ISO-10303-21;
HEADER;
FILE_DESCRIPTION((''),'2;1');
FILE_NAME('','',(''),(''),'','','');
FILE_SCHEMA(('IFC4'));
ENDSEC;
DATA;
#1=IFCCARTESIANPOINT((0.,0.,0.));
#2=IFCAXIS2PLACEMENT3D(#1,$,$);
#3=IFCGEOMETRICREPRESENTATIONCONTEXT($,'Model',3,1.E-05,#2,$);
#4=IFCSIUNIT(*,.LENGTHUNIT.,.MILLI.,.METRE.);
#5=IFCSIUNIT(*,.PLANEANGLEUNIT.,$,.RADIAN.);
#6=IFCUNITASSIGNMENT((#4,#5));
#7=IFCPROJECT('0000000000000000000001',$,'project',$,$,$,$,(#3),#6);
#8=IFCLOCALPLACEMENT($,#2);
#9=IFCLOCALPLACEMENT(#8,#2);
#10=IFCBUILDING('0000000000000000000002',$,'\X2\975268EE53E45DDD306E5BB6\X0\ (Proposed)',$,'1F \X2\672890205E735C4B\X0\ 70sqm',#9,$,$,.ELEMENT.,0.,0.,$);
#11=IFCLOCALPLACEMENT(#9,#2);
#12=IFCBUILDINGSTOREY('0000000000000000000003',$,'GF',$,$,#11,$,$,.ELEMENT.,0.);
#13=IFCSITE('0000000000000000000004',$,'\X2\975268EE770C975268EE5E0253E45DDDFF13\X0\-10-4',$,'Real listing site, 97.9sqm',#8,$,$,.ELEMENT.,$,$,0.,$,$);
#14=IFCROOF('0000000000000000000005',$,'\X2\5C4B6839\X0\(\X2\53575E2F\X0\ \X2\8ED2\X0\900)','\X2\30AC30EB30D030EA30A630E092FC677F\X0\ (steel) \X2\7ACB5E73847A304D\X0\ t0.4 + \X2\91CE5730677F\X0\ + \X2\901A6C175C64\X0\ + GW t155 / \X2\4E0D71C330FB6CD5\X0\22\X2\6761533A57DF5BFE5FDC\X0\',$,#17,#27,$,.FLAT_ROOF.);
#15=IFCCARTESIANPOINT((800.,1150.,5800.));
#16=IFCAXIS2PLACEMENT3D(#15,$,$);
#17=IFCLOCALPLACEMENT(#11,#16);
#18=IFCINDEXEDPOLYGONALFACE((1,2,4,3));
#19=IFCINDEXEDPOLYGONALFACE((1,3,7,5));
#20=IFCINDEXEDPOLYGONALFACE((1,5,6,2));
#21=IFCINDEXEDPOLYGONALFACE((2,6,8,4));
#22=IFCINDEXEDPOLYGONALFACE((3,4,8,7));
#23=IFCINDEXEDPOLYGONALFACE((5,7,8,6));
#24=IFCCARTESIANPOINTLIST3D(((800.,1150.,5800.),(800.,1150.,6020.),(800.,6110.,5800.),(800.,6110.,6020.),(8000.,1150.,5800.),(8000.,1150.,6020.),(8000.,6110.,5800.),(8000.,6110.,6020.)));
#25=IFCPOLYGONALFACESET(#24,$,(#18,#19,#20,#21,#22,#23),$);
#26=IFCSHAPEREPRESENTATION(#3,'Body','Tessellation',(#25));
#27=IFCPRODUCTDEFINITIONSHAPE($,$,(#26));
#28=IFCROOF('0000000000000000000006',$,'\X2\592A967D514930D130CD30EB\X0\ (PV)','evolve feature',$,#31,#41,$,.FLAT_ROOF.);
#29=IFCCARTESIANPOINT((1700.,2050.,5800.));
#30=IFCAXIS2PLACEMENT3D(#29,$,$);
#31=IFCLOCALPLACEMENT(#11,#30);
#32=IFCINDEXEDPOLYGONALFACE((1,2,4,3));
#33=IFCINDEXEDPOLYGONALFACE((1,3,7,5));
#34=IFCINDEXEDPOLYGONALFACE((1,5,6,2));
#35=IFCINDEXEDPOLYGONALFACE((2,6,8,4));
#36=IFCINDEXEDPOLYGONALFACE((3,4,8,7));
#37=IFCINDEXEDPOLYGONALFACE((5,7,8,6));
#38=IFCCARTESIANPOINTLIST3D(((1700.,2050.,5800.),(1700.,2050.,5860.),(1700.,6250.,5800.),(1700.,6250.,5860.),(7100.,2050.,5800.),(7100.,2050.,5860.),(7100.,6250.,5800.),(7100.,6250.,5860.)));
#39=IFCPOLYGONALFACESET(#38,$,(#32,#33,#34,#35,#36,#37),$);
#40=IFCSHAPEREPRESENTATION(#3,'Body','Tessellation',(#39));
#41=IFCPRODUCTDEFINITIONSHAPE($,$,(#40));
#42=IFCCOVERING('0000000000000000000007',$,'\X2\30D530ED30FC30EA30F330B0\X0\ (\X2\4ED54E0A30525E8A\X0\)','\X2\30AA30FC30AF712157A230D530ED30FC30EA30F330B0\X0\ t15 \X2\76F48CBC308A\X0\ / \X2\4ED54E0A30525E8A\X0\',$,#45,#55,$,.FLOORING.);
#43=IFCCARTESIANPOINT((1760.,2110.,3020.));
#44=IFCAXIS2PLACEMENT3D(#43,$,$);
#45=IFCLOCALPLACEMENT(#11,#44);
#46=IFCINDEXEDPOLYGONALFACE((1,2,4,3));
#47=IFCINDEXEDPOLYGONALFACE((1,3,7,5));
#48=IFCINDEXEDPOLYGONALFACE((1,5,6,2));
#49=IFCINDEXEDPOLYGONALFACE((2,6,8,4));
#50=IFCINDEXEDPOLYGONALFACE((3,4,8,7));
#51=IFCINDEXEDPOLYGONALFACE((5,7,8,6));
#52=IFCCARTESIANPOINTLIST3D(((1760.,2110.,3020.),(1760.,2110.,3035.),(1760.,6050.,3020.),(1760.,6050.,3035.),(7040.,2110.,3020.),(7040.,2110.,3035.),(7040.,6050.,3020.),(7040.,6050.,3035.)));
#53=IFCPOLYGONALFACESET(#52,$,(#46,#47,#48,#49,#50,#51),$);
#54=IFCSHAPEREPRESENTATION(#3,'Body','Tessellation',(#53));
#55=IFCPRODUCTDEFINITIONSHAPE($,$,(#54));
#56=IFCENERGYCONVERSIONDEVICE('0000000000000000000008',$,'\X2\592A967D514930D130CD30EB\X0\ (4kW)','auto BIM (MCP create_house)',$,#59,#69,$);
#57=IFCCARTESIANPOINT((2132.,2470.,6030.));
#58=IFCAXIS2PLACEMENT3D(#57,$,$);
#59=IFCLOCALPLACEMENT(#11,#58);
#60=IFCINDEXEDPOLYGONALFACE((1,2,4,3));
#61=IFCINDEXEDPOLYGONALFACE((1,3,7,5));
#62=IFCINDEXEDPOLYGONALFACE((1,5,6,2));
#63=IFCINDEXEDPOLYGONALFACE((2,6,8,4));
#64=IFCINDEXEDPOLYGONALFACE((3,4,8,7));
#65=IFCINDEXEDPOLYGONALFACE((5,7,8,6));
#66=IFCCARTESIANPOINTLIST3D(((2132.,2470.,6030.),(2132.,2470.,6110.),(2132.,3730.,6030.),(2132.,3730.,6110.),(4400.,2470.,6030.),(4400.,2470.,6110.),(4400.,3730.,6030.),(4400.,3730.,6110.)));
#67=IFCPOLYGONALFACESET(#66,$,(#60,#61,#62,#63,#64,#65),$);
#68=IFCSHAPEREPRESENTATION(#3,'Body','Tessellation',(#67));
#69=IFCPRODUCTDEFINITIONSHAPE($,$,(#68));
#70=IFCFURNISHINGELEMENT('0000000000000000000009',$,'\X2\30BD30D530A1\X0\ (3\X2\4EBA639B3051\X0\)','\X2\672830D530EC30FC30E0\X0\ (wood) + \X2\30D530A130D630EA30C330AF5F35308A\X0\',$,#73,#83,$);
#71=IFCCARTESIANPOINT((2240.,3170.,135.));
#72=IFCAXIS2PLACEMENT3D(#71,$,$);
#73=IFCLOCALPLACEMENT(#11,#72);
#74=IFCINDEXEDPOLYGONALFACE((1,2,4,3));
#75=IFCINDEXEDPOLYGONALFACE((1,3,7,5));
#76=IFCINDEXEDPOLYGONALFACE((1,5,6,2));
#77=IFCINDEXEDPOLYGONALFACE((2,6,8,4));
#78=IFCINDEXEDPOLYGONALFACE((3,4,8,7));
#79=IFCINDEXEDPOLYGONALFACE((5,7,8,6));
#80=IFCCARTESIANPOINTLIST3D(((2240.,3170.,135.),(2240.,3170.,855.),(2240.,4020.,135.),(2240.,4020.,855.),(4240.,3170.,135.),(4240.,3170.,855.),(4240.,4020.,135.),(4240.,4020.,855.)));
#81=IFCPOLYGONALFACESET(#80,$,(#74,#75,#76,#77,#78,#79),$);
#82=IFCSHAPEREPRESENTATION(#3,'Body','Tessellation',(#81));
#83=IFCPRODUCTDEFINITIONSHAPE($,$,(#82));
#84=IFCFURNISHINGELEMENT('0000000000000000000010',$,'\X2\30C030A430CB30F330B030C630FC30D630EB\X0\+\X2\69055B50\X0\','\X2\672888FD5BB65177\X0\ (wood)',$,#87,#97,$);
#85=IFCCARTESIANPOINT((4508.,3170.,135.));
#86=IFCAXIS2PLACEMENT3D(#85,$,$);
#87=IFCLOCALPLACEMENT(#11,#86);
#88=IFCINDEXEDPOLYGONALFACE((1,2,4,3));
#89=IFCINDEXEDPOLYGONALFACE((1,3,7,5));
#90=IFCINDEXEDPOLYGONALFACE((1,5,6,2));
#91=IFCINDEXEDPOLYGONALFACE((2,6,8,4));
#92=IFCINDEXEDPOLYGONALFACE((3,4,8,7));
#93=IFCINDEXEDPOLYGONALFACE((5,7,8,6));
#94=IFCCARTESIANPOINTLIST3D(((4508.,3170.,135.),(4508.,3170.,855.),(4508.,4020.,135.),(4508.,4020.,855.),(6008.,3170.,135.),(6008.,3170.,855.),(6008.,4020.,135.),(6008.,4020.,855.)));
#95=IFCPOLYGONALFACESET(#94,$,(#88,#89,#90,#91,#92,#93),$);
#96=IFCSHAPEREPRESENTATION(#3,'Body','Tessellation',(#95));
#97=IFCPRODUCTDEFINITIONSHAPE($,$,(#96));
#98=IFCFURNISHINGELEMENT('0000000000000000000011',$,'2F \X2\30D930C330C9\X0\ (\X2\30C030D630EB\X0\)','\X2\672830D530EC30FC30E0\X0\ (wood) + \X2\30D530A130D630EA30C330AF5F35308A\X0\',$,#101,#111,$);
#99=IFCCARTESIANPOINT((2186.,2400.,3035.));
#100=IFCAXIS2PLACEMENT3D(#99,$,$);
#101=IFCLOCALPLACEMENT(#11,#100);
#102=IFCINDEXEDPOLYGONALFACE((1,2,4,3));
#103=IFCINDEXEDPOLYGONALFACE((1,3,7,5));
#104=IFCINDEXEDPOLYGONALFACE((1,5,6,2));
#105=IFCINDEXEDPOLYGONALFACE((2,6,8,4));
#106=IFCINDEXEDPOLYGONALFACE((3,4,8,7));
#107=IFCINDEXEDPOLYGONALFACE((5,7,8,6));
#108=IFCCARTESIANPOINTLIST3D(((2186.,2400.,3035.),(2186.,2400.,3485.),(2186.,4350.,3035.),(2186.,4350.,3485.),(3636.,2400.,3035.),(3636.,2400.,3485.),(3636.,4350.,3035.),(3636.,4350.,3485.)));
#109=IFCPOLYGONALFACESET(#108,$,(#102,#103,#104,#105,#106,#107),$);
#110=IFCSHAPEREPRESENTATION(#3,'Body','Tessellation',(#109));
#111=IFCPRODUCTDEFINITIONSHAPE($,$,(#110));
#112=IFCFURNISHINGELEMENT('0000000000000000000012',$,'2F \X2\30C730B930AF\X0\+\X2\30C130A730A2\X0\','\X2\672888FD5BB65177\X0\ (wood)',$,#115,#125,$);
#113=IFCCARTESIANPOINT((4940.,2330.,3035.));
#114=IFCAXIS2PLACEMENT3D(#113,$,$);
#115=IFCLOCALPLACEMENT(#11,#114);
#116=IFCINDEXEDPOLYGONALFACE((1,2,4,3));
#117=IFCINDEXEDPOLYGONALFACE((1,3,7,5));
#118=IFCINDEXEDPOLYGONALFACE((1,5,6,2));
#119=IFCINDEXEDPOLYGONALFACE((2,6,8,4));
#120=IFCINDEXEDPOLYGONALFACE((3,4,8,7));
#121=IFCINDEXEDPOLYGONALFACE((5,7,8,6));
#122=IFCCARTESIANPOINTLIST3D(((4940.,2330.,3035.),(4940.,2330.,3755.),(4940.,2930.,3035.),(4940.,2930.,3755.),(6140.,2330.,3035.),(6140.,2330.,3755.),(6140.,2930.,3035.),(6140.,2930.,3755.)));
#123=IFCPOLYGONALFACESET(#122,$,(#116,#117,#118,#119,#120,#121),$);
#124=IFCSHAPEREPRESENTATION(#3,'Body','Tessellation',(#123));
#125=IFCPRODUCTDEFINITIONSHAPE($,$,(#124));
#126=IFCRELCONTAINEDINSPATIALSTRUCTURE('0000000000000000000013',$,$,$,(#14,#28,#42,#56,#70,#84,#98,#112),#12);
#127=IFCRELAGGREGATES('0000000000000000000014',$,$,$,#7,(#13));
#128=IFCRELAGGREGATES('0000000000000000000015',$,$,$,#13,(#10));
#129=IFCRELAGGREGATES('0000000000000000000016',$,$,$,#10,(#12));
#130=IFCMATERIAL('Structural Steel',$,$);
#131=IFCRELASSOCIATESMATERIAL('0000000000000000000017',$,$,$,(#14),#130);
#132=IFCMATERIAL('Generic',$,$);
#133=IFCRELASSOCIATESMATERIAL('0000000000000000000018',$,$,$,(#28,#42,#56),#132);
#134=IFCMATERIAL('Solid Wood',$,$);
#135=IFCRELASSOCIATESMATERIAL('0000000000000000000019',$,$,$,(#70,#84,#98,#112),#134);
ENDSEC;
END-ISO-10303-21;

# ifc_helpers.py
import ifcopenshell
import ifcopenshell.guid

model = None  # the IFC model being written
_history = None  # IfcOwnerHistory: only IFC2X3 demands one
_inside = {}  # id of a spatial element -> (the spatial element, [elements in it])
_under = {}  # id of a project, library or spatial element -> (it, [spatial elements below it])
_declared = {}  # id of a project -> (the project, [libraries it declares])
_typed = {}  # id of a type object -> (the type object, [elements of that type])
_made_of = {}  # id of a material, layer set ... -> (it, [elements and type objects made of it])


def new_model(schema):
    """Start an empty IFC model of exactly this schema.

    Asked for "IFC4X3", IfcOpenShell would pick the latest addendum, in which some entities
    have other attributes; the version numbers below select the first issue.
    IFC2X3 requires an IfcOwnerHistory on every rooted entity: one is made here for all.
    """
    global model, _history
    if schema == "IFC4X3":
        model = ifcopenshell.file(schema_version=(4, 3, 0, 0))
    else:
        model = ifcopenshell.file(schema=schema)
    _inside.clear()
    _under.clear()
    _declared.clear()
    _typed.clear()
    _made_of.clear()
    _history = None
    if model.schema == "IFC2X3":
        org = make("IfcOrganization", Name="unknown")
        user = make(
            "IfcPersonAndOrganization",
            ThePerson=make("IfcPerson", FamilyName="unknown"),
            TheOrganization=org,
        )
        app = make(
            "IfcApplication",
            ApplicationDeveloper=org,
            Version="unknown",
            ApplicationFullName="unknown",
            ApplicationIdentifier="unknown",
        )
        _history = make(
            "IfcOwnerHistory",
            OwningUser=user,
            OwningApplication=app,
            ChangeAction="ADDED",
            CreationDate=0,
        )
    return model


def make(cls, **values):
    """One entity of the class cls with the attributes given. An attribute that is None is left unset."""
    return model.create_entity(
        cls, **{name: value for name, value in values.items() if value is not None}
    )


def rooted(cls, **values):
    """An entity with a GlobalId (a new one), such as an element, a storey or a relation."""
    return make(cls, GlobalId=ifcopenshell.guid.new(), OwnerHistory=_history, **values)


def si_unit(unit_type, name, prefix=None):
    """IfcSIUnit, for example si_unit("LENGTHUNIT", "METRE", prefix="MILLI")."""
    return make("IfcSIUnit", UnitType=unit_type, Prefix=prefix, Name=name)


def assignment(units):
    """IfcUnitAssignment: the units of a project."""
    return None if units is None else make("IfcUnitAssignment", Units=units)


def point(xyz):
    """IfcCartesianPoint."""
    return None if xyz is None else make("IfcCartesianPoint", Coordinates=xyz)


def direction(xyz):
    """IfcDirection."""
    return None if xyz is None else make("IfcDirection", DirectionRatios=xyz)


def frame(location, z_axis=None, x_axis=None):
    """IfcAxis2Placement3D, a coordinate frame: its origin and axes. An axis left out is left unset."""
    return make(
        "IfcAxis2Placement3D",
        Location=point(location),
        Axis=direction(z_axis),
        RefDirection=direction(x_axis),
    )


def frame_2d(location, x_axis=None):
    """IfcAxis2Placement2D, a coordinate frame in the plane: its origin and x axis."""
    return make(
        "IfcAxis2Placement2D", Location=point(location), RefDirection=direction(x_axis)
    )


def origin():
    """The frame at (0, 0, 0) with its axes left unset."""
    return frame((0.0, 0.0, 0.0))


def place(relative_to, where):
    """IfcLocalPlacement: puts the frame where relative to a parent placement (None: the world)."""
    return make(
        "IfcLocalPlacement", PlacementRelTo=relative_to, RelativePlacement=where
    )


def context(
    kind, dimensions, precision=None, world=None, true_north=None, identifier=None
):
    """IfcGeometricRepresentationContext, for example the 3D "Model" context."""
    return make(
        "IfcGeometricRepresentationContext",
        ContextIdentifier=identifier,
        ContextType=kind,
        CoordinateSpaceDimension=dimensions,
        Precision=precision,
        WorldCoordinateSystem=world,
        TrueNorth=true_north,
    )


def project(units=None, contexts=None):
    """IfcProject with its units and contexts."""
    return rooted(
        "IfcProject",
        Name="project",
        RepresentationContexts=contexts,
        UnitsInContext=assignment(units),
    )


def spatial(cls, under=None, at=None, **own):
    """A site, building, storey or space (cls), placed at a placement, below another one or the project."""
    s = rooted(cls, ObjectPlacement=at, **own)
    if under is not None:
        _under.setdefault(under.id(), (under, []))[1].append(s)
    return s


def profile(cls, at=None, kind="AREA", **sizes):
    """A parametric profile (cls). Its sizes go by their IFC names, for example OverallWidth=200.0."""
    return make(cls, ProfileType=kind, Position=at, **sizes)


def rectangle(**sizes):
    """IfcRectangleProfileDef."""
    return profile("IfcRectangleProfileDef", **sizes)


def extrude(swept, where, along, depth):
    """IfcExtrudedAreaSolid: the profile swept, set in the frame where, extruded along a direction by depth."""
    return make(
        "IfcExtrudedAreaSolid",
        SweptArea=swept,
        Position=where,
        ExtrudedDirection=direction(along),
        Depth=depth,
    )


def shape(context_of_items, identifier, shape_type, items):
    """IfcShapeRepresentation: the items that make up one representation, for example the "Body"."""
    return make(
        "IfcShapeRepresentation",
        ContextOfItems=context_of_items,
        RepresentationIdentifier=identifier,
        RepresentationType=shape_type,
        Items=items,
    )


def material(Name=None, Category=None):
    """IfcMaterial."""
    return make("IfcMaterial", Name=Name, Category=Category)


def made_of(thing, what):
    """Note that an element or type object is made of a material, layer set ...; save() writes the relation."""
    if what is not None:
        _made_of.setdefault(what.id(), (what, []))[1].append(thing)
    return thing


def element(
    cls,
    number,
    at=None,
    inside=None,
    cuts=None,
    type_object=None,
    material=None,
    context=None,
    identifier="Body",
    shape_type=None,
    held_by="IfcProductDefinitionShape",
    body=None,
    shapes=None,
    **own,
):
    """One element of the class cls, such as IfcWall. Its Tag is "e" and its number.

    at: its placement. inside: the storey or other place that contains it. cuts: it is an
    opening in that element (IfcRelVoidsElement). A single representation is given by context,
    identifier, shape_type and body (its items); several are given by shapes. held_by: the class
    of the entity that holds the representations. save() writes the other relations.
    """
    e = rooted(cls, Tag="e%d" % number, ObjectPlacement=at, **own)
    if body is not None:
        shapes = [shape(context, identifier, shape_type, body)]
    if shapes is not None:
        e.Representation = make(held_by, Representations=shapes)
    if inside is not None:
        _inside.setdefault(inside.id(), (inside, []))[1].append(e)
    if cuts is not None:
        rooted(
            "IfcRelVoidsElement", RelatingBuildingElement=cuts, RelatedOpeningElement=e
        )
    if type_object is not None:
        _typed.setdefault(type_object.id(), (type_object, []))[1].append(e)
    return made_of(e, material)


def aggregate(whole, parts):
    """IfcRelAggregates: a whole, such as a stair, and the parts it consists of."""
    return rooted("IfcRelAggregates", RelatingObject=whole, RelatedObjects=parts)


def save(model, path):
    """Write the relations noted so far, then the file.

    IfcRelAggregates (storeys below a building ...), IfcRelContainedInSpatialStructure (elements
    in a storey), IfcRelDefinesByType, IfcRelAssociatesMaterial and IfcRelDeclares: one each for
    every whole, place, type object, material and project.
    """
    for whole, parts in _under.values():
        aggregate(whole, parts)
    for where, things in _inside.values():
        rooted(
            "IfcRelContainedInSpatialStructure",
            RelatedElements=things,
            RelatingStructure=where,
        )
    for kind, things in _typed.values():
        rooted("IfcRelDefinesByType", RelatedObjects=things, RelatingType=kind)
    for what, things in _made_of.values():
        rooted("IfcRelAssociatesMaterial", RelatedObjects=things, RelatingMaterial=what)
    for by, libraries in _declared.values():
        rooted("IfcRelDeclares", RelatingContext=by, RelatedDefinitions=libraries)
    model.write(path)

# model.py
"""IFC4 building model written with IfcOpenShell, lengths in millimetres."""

from ifc_helpers import new_model, si_unit, frame, frame_2d, origin, place, context, project, spatial, rectangle, extrude, material, element, save


model = new_model("IFC4")

# Units and contexts
model_context = context("Model", 3, precision=1e-05, world=origin())
ifc_project = project(units=[si_unit("LENGTHUNIT", "METRE", prefix="MILLI"), si_unit("PLANEANGLEUNIT", "RADIAN")], contexts=[model_context])

# Site, building, storey
site_placement = place(None, origin())
site = spatial("IfcSite", under=ifc_project, at=site_placement, Name="青森県青森市古川３-10-4", ObjectType="Real listing site, 97.9sqm", CompositionType="ELEMENT", RefElevation=0.0)
building_placement = place(site_placement, origin())
building = spatial("IfcBuilding", under=site, at=building_placement, Name="青森古川の家 (Proposed)", ObjectType="1F 木造平屋 70sqm", CompositionType="ELEMENT", ElevationOfRefHeight=0.0, ElevationOfTerrain=0.0)
storey_placement = place(building_placement, origin())
storey = spatial("IfcBuildingStorey", under=building, at=storey_placement, Name="GF", CompositionType="ELEMENT", Elevation=0.0)

# Shared definitions
ifc_material_1 = material(Name="Solid Wood")

# Shared definitions
ifc_material_2 = material(Name="Generic")

# Roofs
ifc_material_3 = material(Name="Structural Steel")
for number, where, name in (
    (1, (800.0, 1150.0, 5800.0), "屋根(南帯 軒900)"),
):
    element("IfcRoof", number, at=place(storey_placement, frame(where)), inside=storey, material=ifc_material_3, Name=name, Description="ガルバリウム鋼板 (steel) 立平葺き t0.4 + 野地板 + 通気層 + GW t155 / 不燃・法22条区域対応", PredefinedType="FLAT_ROOF", context=model_context, shape_type="SweptSolid", body=[
        extrude(rectangle(XDim=7200.0, YDim=4960.0, at=frame_2d((3600.0, 2480.0))), frame((800.0, 1150.0, 5800.0)), (0.0, 0.0, 1.0), 220.0),
    ])
roof_placement = place(storey_placement, frame((1700.0, 2050.0, 5800.0)))
element("IfcRoof", 2, at=roof_placement, inside=storey, material=ifc_material_2, Name="太陽光パネル (PV)", Description="evolve feature", PredefinedType="FLAT_ROOF", context=model_context, shape_type="SweptSolid", body=[
    extrude(rectangle(XDim=5400.0, YDim=4200.0, at=frame_2d((2700.0, 2100.0))), frame((1700.0, 2050.0, 5800.0)), (0.0, 0.0, 1.0), 60.0),
])

# Covering
covering_placement = place(storey_placement, frame((1760.0, 2110.0, 3020.0)))
element("IfcCovering", 3, at=covering_placement, inside=storey, material=ifc_material_2, Name="フローリング (仕上げ床)", Description="オーク無垢フローリング t15 直貼り / 仕上げ床", PredefinedType="FLOORING", context=model_context, shape_type="SweptSolid", body=[
    extrude(rectangle(XDim=5280.0, YDim=3940.0, at=frame_2d((2640.0, 1970.0))), frame((1760.0, 2110.0, 3020.0)), (0.0, 0.0, 1.0), 15.0),
])

# Energy conversion device
energy_conversion_device_placement = place(storey_placement, frame((2132.0, 2470.0, 6030.0)))
element("IfcEnergyConversionDevice", 4, at=energy_conversion_device_placement, inside=storey, material=ifc_material_2, Name="太陽光パネル (4kW)", Description="auto BIM (MCP create_house)", context=model_context, shape_type="SweptSolid", body=[
    extrude(rectangle(XDim=2268.0, YDim=1260.0, at=frame_2d((1134.0, 630.0))), frame((2132.0, 2470.0, 6030.0)), (0.0, 0.0, 1.0), 80.0),
])

# Furnishing elements
furnishing_1_placement = place(storey_placement, frame((2240.0, 3170.0, 135.0)))
element("IfcFurnishingElement", 5, at=furnishing_1_placement, inside=storey, material=ifc_material_1, Name="ソファ (3人掛け)", Description="木フレーム (wood) + ファブリック張り", context=model_context, shape_type="SweptSolid", body=[
    extrude(rectangle(XDim=2000.0, YDim=850.0, at=frame_2d((1000.0, 425.0))), frame((2240.0, 3170.0, 135.0)), (0.0, 0.0, 1.0), 720.0),
])
furnishing_2_placement = place(storey_placement, frame((4508.0, 3170.0, 135.0)))
element("IfcFurnishingElement", 6, at=furnishing_2_placement, inside=storey, material=ifc_material_1, Name="ダイニングテーブル+椅子", Description="木製家具 (wood)", context=model_context, shape_type="SweptSolid", body=[
    extrude(rectangle(XDim=1500.0, YDim=850.0, at=frame_2d((750.0, 425.0))), frame((4508.0, 3170.0, 135.0)), (0.0, 0.0, 1.0), 720.0),
])
furnishing_3_placement = place(storey_placement, frame((2186.0, 2400.0, 3035.0)))
element("IfcFurnishingElement", 7, at=furnishing_3_placement, inside=storey, material=ifc_material_1, Name="2F ベッド (ダブル)", Description="木フレーム (wood) + ファブリック張り", context=model_context, shape_type="SweptSolid", body=[
    extrude(rectangle(XDim=1450.0, YDim=1950.0, at=frame_2d((725.0, 975.0))), frame((2186.0, 2400.0, 3035.0)), (0.0, 0.0, 1.0), 450.0),
])
furnishing_4_placement = place(storey_placement, frame((4940.0, 2330.0, 3035.0)))
element("IfcFurnishingElement", 8, at=furnishing_4_placement, inside=storey, material=ifc_material_1, Name="2F デスク+チェア", Description="木製家具 (wood)", context=model_context, shape_type="SweptSolid", body=[
    extrude(rectangle(XDim=1200.0, YDim=600.0, at=frame_2d((600.0, 300.0))), frame((4940.0, 2330.0, 3035.0)), (0.0, 0.0, 1.0), 720.0),
])

save(model, "model.ifc")
